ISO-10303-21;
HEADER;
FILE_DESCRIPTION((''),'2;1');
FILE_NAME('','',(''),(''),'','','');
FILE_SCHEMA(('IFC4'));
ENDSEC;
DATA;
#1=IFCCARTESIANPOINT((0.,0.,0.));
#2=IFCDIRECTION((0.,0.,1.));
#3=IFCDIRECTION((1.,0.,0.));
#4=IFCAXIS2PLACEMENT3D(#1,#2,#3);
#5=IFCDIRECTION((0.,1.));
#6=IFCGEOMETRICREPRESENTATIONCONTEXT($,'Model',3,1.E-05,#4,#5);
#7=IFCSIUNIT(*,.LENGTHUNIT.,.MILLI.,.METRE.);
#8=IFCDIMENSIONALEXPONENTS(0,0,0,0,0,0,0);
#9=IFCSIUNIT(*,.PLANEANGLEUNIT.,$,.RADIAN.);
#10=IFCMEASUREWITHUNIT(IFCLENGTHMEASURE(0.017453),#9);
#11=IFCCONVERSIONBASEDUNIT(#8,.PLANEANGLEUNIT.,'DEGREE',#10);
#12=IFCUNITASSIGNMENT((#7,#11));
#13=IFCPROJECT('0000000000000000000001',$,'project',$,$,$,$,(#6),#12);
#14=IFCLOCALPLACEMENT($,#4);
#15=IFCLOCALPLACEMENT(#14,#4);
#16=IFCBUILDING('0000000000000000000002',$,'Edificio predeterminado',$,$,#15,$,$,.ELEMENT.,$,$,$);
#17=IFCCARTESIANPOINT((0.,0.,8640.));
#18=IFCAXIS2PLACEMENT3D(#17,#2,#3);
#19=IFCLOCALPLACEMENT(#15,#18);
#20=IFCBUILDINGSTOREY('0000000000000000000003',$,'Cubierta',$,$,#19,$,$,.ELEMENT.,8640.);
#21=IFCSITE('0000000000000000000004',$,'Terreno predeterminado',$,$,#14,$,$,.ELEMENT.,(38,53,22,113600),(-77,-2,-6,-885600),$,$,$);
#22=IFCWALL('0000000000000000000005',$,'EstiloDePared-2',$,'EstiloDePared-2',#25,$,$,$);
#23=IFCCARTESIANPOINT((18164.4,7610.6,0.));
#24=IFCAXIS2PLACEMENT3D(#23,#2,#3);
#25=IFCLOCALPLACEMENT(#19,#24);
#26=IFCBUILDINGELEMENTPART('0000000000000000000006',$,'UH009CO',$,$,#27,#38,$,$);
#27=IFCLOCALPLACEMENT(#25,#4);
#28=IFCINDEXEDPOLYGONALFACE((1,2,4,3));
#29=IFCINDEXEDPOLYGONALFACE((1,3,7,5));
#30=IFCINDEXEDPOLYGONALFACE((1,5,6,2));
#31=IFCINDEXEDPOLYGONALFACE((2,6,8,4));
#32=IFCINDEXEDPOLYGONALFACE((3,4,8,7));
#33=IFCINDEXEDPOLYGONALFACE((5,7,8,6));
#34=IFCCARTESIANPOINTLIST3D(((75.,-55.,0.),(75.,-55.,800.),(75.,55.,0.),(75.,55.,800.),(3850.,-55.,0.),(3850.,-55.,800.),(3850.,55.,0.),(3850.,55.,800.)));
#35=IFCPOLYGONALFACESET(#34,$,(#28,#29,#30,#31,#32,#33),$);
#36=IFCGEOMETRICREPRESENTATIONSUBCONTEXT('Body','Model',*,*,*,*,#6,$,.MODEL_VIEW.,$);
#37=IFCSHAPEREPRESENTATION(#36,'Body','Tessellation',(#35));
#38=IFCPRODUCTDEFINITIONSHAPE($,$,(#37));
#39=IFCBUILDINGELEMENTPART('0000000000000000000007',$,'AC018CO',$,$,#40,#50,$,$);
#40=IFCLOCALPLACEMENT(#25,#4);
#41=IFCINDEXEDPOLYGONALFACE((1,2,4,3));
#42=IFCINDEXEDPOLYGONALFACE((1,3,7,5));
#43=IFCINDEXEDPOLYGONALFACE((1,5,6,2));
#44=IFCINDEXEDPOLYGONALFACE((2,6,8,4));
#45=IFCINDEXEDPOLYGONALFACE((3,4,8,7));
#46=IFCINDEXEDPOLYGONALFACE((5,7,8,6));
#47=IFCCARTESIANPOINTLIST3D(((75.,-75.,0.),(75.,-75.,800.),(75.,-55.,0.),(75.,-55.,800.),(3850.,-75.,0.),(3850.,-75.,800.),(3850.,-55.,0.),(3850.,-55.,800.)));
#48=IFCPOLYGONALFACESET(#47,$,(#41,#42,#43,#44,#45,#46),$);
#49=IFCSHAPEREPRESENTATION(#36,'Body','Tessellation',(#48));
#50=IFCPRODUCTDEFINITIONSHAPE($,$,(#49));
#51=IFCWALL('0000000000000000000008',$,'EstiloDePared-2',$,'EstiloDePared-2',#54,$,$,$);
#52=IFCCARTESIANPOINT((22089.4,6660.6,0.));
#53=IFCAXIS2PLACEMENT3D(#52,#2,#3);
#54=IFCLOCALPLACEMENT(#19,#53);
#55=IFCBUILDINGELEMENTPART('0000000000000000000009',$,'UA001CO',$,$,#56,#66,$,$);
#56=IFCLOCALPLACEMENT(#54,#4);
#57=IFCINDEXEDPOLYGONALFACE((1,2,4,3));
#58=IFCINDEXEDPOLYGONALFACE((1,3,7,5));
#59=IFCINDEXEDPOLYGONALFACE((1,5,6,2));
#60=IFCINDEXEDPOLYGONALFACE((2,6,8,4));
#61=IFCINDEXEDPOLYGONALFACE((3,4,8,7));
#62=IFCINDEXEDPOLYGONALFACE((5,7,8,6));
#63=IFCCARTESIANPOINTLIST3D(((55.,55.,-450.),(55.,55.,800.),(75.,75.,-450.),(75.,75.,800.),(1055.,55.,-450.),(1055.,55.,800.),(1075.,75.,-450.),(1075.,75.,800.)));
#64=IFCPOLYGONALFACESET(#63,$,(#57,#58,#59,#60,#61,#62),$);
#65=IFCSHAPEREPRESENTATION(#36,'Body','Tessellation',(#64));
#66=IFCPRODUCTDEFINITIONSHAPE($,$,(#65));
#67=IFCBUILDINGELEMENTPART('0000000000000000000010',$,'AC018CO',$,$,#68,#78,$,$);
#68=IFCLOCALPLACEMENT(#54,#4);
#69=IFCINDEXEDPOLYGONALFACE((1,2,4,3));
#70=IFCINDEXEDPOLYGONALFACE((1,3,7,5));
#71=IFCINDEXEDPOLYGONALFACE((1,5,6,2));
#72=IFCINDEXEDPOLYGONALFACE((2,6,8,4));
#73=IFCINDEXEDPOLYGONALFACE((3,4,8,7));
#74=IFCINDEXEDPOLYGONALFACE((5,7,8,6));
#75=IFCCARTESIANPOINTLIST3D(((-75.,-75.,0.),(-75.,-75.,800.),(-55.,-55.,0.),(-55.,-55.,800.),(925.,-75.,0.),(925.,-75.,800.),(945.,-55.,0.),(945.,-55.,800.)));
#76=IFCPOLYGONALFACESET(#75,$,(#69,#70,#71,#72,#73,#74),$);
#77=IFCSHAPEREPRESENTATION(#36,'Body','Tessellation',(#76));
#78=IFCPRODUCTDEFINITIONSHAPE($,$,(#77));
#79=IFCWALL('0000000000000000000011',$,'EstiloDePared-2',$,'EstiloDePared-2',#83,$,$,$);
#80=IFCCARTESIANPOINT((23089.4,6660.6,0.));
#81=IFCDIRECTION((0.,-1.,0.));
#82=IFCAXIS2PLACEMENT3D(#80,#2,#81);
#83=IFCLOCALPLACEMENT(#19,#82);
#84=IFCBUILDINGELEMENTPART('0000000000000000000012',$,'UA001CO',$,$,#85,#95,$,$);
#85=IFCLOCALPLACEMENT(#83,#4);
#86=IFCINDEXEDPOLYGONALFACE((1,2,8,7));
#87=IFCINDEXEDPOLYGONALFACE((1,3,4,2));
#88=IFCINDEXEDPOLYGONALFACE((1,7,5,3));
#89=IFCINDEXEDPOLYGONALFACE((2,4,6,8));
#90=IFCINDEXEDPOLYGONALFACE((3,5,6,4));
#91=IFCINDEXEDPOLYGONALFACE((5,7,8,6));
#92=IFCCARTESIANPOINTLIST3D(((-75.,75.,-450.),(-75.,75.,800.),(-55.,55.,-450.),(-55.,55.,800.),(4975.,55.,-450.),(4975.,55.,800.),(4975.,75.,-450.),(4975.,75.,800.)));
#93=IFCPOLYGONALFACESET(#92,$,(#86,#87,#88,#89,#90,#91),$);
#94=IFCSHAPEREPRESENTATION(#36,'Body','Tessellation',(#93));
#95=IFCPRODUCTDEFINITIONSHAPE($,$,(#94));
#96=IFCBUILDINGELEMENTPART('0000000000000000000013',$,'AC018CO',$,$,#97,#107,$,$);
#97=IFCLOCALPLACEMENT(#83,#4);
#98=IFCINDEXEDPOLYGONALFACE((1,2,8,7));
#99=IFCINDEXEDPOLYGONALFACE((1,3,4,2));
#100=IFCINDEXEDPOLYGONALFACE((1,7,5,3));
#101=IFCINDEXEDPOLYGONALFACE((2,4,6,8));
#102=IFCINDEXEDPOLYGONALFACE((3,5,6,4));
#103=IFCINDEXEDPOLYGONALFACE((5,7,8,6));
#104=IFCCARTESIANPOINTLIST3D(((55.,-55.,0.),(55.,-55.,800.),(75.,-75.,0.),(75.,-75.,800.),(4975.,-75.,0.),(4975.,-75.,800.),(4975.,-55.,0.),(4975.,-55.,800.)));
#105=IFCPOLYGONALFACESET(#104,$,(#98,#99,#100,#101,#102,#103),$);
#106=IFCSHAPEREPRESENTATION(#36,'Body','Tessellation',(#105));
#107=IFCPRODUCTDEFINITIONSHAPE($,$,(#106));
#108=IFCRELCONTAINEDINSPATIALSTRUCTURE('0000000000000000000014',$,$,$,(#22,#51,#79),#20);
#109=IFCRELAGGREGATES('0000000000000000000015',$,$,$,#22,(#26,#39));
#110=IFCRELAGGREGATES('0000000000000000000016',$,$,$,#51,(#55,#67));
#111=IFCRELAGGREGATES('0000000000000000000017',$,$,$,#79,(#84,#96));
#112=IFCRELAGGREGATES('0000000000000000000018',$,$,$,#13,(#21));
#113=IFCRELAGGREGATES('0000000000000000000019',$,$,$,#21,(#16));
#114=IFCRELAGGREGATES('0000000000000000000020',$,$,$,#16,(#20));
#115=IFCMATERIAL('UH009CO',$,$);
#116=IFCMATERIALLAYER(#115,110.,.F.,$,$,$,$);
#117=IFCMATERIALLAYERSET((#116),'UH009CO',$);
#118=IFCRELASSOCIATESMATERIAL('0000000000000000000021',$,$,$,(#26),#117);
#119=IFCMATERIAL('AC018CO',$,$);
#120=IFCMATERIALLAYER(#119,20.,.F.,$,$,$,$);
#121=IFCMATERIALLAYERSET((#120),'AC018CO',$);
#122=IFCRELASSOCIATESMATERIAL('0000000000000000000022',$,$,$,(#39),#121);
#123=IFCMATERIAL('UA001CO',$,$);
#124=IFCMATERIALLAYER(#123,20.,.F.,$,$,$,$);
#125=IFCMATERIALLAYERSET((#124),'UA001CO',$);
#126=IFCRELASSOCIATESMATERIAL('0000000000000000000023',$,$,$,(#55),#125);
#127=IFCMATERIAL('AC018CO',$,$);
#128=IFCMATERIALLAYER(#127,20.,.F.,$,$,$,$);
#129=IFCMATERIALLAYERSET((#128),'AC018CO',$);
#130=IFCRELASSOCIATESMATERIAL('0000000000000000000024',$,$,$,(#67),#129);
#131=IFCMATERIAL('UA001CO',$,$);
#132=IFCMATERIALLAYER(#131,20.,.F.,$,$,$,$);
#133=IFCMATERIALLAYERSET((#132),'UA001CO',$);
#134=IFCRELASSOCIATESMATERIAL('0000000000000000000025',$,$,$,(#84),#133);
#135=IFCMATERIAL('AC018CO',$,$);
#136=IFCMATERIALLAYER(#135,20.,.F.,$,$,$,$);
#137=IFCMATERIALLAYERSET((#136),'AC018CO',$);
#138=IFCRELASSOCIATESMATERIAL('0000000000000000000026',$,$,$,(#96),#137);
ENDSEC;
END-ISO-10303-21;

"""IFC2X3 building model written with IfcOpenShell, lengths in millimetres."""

from ifc_helpers import new_model, entity, si_unit, converted_unit, direction, frame, origin_with_axes, place, context, subcontext, project, spatial, polyline, outline, extrude, material, layer, layer_set, layer_usage, element, aggregate, save


model = new_model("IFC2X3")

# Units and contexts
model_context = context("Model", 3, precision=1e-05, world=origin_with_axes(), true_north=direction((0.0, 1.0)))
body_context = subcontext(model_context, "Body", "Model", "MODEL_VIEW")
ifc_project = project(units=[si_unit("LENGTHUNIT", "METRE", prefix="MILLI"), converted_unit("PLANEANGLEUNIT", "DEGREE", entity("IfcLengthMeasure", 0.017453), si_unit("PLANEANGLEUNIT", "RADIAN"), dimensions=[0, 0, 0, 0, 0, 0, 0])], contexts=[model_context])

# Site, building, storey
site_placement = place(None, origin_with_axes())
site = spatial("IfcSite", under=ifc_project, at=site_placement, Name="Terreno predeterminado", CompositionType="ELEMENT", RefLatitude=(38, 53, 22, 113600), RefLongitude=(-77, -2, -6, -885600))
building_placement = place(site_placement, origin_with_axes())
building = spatial("IfcBuilding", under=site, at=building_placement, Name="Edificio predeterminado", CompositionType="ELEMENT")
storey_placement = place(building_placement, frame((0.0, 0.0, 8640.0), z_axis=(0.0, 0.0, 1.0), x_axis=(1.0, 0.0, 0.0)))
storey = spatial("IfcBuildingStorey", under=building, at=storey_placement, Name="Cubierta", CompositionType="ELEMENT", Elevation=8640.0)

# Walls, building element parts
wall_1_placement = place(storey_placement, frame((18164.4, 7610.6, 0.0), z_axis=(0.0, 0.0, 1.0), x_axis=(1.0, 0.0, 0.0)))
wall_1 = element("IfcWall", 1, at=wall_1_placement, inside=storey, Name="EstiloDePared-2", ObjectType="EstiloDePared-2")
ifc_material_1 = material(Name="UH009CO")
ifc_layer_1 = layer(ifc_material_1, 110.0, ventilated=False)
ifc_layer_set_1 = layer_set([ifc_layer_1], Name="UH009CO")
ifc_layer_usage_1 = layer_usage(ifc_layer_set_1, "AXIS2", "NEGATIVE", -55.0)
building_element_part_1_placement = place(wall_1_placement, origin_with_axes())
building_element_part_1 = element("IfcBuildingElementPart", 2, at=building_element_part_1_placement, material=ifc_layer_usage_1, Name="UH009CO", context=body_context, shape_type="SweptSolid", body=[
    extrude(outline(polyline([(3850.0, 55.0), (3850.0, -55.0), (75.0, -55.0), (75.0, 55.0), (3850.0, 55.0)])), origin_with_axes(), (0.0, 0.0, 1.0), 800.0),
])
ifc_material_2 = material(Name="AC018CO")
ifc_layer_2 = layer(ifc_material_2, 20.0, ventilated=False)
ifc_layer_set_2 = layer_set([ifc_layer_2], Name="AC018CO")
ifc_layer_usage_2 = layer_usage(ifc_layer_set_2, "AXIS2", "NEGATIVE", 55.0)
building_element_part_2_placement = place(wall_1_placement, origin_with_axes())
building_element_part_2 = element("IfcBuildingElementPart", 3, at=building_element_part_2_placement, material=ifc_layer_usage_2, Name="AC018CO", context=body_context, shape_type="SweptSolid", body=[
    extrude(outline(polyline([(3850.0, -55.0), (3850.0, -75.0), (75.0, -75.0), (75.0, -55.0), (3850.0, -55.0)])), origin_with_axes(), (0.0, 0.0, 1.0), 800.0),
])
aggregate(wall_1, [building_element_part_1, building_element_part_2])
wall_2_placement = place(storey_placement, frame((22089.4, 6660.6, 0.0), z_axis=(0.0, 0.0, 1.0), x_axis=(1.0, 0.0, 0.0)))
wall_2 = element("IfcWall", 4, at=wall_2_placement, inside=storey, Name="EstiloDePared-2", ObjectType="EstiloDePared-2")
ifc_material_3 = material(Name="UA001CO")
ifc_layer_3 = layer(ifc_material_3, 20.0, ventilated=False)
ifc_layer_set_3 = layer_set([ifc_layer_3], Name="UA001CO")
ifc_layer_usage_3 = layer_usage(ifc_layer_set_3, "AXIS2", "NEGATIVE", -75.0)
building_element_part_3_placement = place(wall_2_placement, origin_with_axes())
building_element_part_3 = element("IfcBuildingElementPart", 5, at=building_element_part_3_placement, material=ifc_layer_usage_3, Name="UA001CO", context=body_context, shape_type="SweptSolid", body=[
    extrude(outline(polyline([(1075.0, 75.0), (1055.0, 55.0), (55.0, 55.0), (75.0, 75.0), (1075.0, 75.0)])), frame((0.0, 0.0, -450.0), z_axis=(0.0, 0.0, 1.0), x_axis=(1.0, 0.0, 0.0)), (0.0, 0.0, 1.0), 1250.0),
])
ifc_material_4 = material(Name="AC018CO")
ifc_layer_4 = layer(ifc_material_4, 20.0, ventilated=False)
ifc_layer_set_4 = layer_set([ifc_layer_4], Name="AC018CO")
ifc_layer_usage_4 = layer_usage(ifc_layer_set_4, "AXIS2", "NEGATIVE", 55.0)
building_element_part_4_placement = place(wall_2_placement, origin_with_axes())
building_element_part_4 = element("IfcBuildingElementPart", 6, at=building_element_part_4_placement, material=ifc_layer_usage_4, Name="AC018CO", context=body_context, shape_type="SweptSolid", body=[
    extrude(outline(polyline([(945.0, -55.0), (925.0, -75.0), (-75.0, -75.0), (-55.0, -55.0), (945.0, -55.0)])), origin_with_axes(), (0.0, 0.0, 1.0), 800.0),
])
aggregate(wall_2, [building_element_part_3, building_element_part_4])
wall_3_placement = place(storey_placement, frame((23089.4, 6660.6, 0.0), z_axis=(0.0, 0.0, 1.0), x_axis=(0.0, -1.0, 0.0)))
wall_3 = element("IfcWall", 7, at=wall_3_placement, inside=storey, Name="EstiloDePared-2", ObjectType="EstiloDePared-2")
ifc_material_5 = material(Name="UA001CO")
ifc_layer_5 = layer(ifc_material_5, 20.0, ventilated=False)
ifc_layer_set_5 = layer_set([ifc_layer_5], Name="UA001CO")
ifc_layer_usage_5 = layer_usage(ifc_layer_set_5, "AXIS2", "NEGATIVE", -75.0)
building_element_part_5_placement = place(wall_3_placement, origin_with_axes())
building_element_part_5 = element("IfcBuildingElementPart", 8, at=building_element_part_5_placement, material=ifc_layer_usage_5, Name="UA001CO", context=body_context, shape_type="SweptSolid", body=[
    extrude(outline(polyline([(4975.0, 75.0), (4975.0, 55.0), (-55.0, 55.0), (-75.0, 75.0), (4975.0, 75.0)])), frame((0.0, 0.0, -450.0), z_axis=(0.0, 0.0, 1.0), x_axis=(1.0, 0.0, 0.0)), (0.0, 0.0, 1.0), 1250.0),
])
ifc_material_6 = material(Name="AC018CO")
ifc_layer_6 = layer(ifc_material_6, 20.0, ventilated=False)
ifc_layer_set_6 = layer_set([ifc_layer_6], Name="AC018CO")
ifc_layer_usage_6 = layer_usage(ifc_layer_set_6, "AXIS2", "NEGATIVE", 55.0)
building_element_part_6_placement = place(wall_3_placement, origin_with_axes())
building_element_part_6 = element("IfcBuildingElementPart", 9, at=building_element_part_6_placement, material=ifc_layer_usage_6, Name="AC018CO", context=body_context, shape_type="SweptSolid", body=[
    extrude(outline(polyline([(4975.0, -55.0), (4975.0, -75.0), (75.0, -75.0), (55.0, -55.0), (4975.0, -55.0)])), origin_with_axes(), (0.0, 0.0, 1.0), 800.0),
])
aggregate(wall_3, [building_element_part_5, building_element_part_6])

save(model, "model.ifc")
